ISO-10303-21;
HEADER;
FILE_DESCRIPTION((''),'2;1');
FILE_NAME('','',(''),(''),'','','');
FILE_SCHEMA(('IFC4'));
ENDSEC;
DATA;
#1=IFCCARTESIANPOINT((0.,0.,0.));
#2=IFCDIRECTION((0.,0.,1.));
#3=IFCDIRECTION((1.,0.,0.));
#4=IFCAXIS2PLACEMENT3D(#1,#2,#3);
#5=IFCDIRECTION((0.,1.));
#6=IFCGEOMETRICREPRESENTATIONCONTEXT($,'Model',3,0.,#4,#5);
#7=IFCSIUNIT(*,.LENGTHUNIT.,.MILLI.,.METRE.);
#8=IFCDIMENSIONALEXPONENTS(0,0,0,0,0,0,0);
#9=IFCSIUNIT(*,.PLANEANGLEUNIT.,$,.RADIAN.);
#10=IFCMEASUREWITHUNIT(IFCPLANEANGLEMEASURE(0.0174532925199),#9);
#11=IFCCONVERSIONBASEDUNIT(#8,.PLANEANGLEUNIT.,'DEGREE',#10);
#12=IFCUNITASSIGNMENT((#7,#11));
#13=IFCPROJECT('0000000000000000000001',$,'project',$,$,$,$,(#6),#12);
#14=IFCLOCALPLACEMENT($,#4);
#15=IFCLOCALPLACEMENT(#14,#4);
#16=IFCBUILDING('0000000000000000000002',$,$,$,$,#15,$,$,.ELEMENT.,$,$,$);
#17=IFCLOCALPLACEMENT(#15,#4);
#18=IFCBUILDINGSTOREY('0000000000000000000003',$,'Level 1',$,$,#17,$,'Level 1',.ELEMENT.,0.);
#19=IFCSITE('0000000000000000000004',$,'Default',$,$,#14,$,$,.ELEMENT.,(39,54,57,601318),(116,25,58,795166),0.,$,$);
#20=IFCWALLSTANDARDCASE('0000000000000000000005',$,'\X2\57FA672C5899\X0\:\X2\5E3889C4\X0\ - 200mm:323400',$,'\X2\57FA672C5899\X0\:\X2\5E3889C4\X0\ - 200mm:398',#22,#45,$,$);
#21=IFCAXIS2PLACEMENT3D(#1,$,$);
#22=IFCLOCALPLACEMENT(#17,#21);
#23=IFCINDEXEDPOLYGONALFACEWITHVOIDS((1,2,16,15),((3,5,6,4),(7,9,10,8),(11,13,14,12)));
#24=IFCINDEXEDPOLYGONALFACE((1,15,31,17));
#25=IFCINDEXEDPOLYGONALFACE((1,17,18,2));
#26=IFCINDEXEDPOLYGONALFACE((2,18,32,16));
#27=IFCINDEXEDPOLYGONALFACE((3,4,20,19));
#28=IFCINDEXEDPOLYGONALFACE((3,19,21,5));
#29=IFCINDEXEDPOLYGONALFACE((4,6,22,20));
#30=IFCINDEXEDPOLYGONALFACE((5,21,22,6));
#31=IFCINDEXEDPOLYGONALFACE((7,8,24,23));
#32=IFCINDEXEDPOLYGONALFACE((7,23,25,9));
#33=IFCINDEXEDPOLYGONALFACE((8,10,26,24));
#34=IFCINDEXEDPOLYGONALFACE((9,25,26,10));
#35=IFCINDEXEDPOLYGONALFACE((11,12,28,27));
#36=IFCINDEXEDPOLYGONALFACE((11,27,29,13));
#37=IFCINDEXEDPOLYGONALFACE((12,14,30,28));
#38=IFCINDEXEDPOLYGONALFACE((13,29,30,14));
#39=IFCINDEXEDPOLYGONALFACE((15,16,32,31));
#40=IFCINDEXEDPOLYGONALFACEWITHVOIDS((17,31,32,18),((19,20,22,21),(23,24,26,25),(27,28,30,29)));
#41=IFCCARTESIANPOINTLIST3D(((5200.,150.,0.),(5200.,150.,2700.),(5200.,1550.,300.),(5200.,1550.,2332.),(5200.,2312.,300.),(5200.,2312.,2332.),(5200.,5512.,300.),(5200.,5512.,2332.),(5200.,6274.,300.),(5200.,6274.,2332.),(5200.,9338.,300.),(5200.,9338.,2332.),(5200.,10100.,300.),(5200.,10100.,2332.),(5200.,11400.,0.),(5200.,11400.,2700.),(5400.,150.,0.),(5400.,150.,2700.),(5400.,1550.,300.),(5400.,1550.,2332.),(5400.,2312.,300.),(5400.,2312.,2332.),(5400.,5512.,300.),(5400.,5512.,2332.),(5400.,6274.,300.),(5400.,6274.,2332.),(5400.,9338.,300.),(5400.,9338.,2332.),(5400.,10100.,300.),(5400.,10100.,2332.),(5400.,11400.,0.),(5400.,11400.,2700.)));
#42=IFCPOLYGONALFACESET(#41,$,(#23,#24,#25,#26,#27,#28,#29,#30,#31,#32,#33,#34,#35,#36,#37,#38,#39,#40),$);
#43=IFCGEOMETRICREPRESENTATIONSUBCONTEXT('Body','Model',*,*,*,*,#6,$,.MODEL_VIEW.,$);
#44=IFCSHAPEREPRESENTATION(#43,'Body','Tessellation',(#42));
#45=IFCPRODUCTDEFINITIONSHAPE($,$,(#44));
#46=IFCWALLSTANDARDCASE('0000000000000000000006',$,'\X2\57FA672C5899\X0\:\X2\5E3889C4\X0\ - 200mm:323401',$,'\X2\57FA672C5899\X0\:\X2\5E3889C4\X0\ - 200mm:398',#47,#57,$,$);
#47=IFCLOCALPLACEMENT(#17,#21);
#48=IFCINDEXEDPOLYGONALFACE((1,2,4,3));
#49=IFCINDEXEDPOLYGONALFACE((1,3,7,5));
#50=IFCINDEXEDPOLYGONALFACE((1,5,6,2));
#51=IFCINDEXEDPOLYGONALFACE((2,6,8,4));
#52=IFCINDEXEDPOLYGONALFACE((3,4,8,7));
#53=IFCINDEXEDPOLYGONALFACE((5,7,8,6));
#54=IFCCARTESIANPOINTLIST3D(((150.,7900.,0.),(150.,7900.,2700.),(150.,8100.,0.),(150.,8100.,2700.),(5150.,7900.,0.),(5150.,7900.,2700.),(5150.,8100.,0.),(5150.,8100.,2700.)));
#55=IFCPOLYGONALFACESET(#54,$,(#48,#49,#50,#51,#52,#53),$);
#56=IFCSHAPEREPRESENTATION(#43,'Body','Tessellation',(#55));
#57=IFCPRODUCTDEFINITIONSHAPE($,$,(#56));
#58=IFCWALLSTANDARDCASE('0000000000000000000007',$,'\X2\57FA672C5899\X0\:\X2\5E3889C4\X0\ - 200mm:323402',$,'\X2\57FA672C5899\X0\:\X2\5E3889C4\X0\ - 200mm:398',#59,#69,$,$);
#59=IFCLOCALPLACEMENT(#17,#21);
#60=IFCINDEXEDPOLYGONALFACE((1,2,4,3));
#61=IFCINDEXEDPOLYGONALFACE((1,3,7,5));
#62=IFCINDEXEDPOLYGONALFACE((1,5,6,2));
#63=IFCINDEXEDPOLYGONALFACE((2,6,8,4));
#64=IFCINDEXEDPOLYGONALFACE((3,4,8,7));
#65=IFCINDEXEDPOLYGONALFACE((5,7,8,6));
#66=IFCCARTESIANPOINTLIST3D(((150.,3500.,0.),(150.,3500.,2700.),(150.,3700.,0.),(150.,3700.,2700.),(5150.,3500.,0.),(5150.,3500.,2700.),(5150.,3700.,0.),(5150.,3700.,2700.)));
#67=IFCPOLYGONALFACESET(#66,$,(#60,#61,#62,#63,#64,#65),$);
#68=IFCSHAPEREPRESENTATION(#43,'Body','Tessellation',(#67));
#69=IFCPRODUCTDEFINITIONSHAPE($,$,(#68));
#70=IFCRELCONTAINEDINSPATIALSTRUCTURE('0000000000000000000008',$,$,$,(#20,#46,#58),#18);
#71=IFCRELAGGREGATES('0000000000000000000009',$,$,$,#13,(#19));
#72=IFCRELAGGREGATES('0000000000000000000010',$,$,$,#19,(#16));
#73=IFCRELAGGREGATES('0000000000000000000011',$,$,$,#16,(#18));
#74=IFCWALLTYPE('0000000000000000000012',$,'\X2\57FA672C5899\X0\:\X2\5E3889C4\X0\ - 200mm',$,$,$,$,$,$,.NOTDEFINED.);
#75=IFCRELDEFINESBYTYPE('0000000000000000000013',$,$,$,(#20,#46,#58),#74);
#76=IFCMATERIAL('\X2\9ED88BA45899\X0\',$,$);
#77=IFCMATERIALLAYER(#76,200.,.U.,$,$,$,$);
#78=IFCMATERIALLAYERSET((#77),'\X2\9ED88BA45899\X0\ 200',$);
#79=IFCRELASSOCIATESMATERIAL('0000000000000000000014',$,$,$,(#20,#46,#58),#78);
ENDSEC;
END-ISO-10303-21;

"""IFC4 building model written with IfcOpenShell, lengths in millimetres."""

from ifc_helpers import new_model, entity, si_unit, converted_unit, direction, frame, origin_with_axes, place, context, subcontext, project, spatial, polyline, outline, extrude, clip, halfspace, material, layer, layer_set, layer_usage, type_object, element, save


model = new_model("IFC4")

# Units and contexts
model_context = context("Model", 3, precision=0.0, world=origin_with_axes(), true_north=direction((0.0, 1.0)))
body_context = subcontext(model_context, "Body", "Model", "MODEL_VIEW")
ifc_project = project(units=[si_unit("LENGTHUNIT", "METRE", prefix="MILLI"), converted_unit("PLANEANGLEUNIT", "DEGREE", entity("IfcPlaneAngleMeasure", 0.0174532925199), si_unit("PLANEANGLEUNIT", "RADIAN"), dimensions=[0, 0, 0, 0, 0, 0, 0])], contexts=[model_context])

# Site, building, storey
site_placement = place(None, origin_with_axes())
site = spatial("IfcSite", under=ifc_project, at=site_placement, Name="Default", CompositionType="ELEMENT", RefLatitude=(39, 54, 57, 601318), RefLongitude=(116, 25, 58, 795166), RefElevation=0.0)
building_placement = place(site_placement, origin_with_axes())
building = spatial("IfcBuilding", under=site, at=building_placement, CompositionType="ELEMENT")
storey_placement = place(building_placement, origin_with_axes())
storey = spatial("IfcBuildingStorey", under=building, at=storey_placement, Name="Level 1", LongName="Level 1", CompositionType="ELEMENT", Elevation=0.0)

# Shared definitions
ifc_material_1 = material(Name="默认墙")
ifc_layer_1 = layer(ifc_material_1, 200.0, ventilated="UNKNOWN")
ifc_layer_set_1 = layer_set([ifc_layer_1], Name="默认墙 200")
wall_type = type_object("IfcWallType", Name="基本墙:常规 - 200mm", PredefinedType="NOTDEFINED")

# Wall, openings
ifc_layer_usage_1 = layer_usage(ifc_layer_set_1, "AXIS2", "POSITIVE", -100.0)
wall_1_placement = place(storey_placement, frame((5300.0, 11500.0, 0.0), z_axis=(0.0, 0.0, 1.0), x_axis=(0.0, -1.0, 0.0)))
wall_1 = element("IfcWallStandardCase", 1, at=wall_1_placement, inside=storey, type_object=wall_type, material=ifc_layer_usage_1, Name="基本墙:常规 - 200mm:323400", ObjectType="基本墙:常规 - 200mm:398", context=body_context, shape_type="Clipping", body=[
    clip(extrude(outline(polyline([(100.0, -100.0), (11350.0, -100.0), (11350.0, 100.0), (100.0, 100.0), (100.0, -100.0)])), origin_with_axes(), (0.0, 0.0, 1.0), 2700.0), halfspace(frame((0.0, 0.0, 2700.0), z_axis=(0.0, 0.0, -1.0), x_axis=(0.0, 1.0, 0.0)), True)),
])
opening_1_placement = place(wall_1_placement, frame((9569.0, 0.0, 300.0), z_axis=(0.0, 0.0, 1.0), x_axis=(1.0, 0.0, 0.0)))
element("IfcOpeningElement", 2, at=opening_1_placement, cuts=wall_1, context=body_context, shape_type="SweptSolid", body=[
    extrude(outline(polyline([(-381.0, -2032.0), (381.0, -2032.0), (381.0, 0.0), (-381.0, 0.0), (-381.0, -2032.0)])), frame((0.0, -100.0, 0.0), z_axis=(0.0, 1.0, 0.0), x_axis=(1.0, 0.0, 0.0)), (0.0, 0.0, 1.0), 200.0),
])
opening_2_placement = place(wall_1_placement, frame((5607.0, 0.0, 300.0), z_axis=(0.0, 0.0, 1.0), x_axis=(1.0, 0.0, 0.0)))
element("IfcOpeningElement", 3, at=opening_2_placement, cuts=wall_1, context=body_context, shape_type="SweptSolid", body=[
    extrude(outline(polyline([(-381.0, -2032.0), (381.0, -2032.0), (381.0, 0.0), (-381.0, 0.0), (-381.0, -2032.0)])), frame((0.0, -100.0, 0.0), z_axis=(0.0, 1.0, 0.0), x_axis=(1.0, 0.0, 0.0)), (0.0, 0.0, 1.0), 200.0),
])
opening_3_placement = place(wall_1_placement, frame((1781.0, 0.0, 300.0), z_axis=(0.0, 0.0, 1.0), x_axis=(1.0, 0.0, 0.0)))
element("IfcOpeningElement", 4, at=opening_3_placement, cuts=wall_1, context=body_context, shape_type="SweptSolid", body=[
    extrude(outline(polyline([(-381.0, -2032.0), (381.0, -2032.0), (381.0, 0.0), (-381.0, 0.0), (-381.0, -2032.0)])), frame((0.0, -100.0, 0.0), z_axis=(0.0, 1.0, 0.0), x_axis=(1.0, 0.0, 0.0)), (0.0, 0.0, 1.0), 200.0),
])

# Walls
ifc_layer_usage_2 = layer_usage(ifc_layer_set_1, "AXIS2", "POSITIVE", -100.0)
wall_2_placement = place(storey_placement, frame((150.0, 8000.0, 0.0), z_axis=(0.0, 0.0, 1.0), x_axis=(1.0, 0.0, 0.0)))
element("IfcWallStandardCase", 5, at=wall_2_placement, inside=storey, type_object=wall_type, material=ifc_layer_usage_2, Name="基本墙:常规 - 200mm:323401", ObjectType="基本墙:常规 - 200mm:398", context=body_context, shape_type="Clipping", body=[
    clip(extrude(outline(polyline([(0.0, -100.0), (5000.0, -100.0), (5000.0, 100.0), (0.0, 100.0), (0.0, -100.0)])), origin_with_axes(), (0.0, 0.0, 1.0), 2700.0), halfspace(frame((0.0, 0.0, 2700.0), z_axis=(0.0, 0.0, -1.0), x_axis=(0.0, 1.0, 0.0)), True)),
])
ifc_layer_usage_3 = layer_usage(ifc_layer_set_1, "AXIS2", "POSITIVE", -100.0)
wall_3_placement = place(storey_placement, frame((150.0, 3600.0, 0.0), z_axis=(0.0, 0.0, 1.0), x_axis=(1.0, 0.0, 0.0)))
element("IfcWallStandardCase", 6, at=wall_3_placement, inside=storey, type_object=wall_type, material=ifc_layer_usage_3, Name="基本墙:常规 - 200mm:323402", ObjectType="基本墙:常规 - 200mm:398", context=body_context, shape_type="Clipping", body=[
    clip(extrude(outline(polyline([(0.0, -100.0), (5000.0, -100.0), (5000.0, 100.0), (0.0, 100.0), (0.0, -100.0)])), origin_with_axes(), (0.0, 0.0, 1.0), 2700.0), halfspace(frame((0.0, 0.0, 2700.0), z_axis=(0.0, 0.0, -1.0), x_axis=(0.0, 1.0, 0.0)), True)),
])

save(model, "model.ifc")
